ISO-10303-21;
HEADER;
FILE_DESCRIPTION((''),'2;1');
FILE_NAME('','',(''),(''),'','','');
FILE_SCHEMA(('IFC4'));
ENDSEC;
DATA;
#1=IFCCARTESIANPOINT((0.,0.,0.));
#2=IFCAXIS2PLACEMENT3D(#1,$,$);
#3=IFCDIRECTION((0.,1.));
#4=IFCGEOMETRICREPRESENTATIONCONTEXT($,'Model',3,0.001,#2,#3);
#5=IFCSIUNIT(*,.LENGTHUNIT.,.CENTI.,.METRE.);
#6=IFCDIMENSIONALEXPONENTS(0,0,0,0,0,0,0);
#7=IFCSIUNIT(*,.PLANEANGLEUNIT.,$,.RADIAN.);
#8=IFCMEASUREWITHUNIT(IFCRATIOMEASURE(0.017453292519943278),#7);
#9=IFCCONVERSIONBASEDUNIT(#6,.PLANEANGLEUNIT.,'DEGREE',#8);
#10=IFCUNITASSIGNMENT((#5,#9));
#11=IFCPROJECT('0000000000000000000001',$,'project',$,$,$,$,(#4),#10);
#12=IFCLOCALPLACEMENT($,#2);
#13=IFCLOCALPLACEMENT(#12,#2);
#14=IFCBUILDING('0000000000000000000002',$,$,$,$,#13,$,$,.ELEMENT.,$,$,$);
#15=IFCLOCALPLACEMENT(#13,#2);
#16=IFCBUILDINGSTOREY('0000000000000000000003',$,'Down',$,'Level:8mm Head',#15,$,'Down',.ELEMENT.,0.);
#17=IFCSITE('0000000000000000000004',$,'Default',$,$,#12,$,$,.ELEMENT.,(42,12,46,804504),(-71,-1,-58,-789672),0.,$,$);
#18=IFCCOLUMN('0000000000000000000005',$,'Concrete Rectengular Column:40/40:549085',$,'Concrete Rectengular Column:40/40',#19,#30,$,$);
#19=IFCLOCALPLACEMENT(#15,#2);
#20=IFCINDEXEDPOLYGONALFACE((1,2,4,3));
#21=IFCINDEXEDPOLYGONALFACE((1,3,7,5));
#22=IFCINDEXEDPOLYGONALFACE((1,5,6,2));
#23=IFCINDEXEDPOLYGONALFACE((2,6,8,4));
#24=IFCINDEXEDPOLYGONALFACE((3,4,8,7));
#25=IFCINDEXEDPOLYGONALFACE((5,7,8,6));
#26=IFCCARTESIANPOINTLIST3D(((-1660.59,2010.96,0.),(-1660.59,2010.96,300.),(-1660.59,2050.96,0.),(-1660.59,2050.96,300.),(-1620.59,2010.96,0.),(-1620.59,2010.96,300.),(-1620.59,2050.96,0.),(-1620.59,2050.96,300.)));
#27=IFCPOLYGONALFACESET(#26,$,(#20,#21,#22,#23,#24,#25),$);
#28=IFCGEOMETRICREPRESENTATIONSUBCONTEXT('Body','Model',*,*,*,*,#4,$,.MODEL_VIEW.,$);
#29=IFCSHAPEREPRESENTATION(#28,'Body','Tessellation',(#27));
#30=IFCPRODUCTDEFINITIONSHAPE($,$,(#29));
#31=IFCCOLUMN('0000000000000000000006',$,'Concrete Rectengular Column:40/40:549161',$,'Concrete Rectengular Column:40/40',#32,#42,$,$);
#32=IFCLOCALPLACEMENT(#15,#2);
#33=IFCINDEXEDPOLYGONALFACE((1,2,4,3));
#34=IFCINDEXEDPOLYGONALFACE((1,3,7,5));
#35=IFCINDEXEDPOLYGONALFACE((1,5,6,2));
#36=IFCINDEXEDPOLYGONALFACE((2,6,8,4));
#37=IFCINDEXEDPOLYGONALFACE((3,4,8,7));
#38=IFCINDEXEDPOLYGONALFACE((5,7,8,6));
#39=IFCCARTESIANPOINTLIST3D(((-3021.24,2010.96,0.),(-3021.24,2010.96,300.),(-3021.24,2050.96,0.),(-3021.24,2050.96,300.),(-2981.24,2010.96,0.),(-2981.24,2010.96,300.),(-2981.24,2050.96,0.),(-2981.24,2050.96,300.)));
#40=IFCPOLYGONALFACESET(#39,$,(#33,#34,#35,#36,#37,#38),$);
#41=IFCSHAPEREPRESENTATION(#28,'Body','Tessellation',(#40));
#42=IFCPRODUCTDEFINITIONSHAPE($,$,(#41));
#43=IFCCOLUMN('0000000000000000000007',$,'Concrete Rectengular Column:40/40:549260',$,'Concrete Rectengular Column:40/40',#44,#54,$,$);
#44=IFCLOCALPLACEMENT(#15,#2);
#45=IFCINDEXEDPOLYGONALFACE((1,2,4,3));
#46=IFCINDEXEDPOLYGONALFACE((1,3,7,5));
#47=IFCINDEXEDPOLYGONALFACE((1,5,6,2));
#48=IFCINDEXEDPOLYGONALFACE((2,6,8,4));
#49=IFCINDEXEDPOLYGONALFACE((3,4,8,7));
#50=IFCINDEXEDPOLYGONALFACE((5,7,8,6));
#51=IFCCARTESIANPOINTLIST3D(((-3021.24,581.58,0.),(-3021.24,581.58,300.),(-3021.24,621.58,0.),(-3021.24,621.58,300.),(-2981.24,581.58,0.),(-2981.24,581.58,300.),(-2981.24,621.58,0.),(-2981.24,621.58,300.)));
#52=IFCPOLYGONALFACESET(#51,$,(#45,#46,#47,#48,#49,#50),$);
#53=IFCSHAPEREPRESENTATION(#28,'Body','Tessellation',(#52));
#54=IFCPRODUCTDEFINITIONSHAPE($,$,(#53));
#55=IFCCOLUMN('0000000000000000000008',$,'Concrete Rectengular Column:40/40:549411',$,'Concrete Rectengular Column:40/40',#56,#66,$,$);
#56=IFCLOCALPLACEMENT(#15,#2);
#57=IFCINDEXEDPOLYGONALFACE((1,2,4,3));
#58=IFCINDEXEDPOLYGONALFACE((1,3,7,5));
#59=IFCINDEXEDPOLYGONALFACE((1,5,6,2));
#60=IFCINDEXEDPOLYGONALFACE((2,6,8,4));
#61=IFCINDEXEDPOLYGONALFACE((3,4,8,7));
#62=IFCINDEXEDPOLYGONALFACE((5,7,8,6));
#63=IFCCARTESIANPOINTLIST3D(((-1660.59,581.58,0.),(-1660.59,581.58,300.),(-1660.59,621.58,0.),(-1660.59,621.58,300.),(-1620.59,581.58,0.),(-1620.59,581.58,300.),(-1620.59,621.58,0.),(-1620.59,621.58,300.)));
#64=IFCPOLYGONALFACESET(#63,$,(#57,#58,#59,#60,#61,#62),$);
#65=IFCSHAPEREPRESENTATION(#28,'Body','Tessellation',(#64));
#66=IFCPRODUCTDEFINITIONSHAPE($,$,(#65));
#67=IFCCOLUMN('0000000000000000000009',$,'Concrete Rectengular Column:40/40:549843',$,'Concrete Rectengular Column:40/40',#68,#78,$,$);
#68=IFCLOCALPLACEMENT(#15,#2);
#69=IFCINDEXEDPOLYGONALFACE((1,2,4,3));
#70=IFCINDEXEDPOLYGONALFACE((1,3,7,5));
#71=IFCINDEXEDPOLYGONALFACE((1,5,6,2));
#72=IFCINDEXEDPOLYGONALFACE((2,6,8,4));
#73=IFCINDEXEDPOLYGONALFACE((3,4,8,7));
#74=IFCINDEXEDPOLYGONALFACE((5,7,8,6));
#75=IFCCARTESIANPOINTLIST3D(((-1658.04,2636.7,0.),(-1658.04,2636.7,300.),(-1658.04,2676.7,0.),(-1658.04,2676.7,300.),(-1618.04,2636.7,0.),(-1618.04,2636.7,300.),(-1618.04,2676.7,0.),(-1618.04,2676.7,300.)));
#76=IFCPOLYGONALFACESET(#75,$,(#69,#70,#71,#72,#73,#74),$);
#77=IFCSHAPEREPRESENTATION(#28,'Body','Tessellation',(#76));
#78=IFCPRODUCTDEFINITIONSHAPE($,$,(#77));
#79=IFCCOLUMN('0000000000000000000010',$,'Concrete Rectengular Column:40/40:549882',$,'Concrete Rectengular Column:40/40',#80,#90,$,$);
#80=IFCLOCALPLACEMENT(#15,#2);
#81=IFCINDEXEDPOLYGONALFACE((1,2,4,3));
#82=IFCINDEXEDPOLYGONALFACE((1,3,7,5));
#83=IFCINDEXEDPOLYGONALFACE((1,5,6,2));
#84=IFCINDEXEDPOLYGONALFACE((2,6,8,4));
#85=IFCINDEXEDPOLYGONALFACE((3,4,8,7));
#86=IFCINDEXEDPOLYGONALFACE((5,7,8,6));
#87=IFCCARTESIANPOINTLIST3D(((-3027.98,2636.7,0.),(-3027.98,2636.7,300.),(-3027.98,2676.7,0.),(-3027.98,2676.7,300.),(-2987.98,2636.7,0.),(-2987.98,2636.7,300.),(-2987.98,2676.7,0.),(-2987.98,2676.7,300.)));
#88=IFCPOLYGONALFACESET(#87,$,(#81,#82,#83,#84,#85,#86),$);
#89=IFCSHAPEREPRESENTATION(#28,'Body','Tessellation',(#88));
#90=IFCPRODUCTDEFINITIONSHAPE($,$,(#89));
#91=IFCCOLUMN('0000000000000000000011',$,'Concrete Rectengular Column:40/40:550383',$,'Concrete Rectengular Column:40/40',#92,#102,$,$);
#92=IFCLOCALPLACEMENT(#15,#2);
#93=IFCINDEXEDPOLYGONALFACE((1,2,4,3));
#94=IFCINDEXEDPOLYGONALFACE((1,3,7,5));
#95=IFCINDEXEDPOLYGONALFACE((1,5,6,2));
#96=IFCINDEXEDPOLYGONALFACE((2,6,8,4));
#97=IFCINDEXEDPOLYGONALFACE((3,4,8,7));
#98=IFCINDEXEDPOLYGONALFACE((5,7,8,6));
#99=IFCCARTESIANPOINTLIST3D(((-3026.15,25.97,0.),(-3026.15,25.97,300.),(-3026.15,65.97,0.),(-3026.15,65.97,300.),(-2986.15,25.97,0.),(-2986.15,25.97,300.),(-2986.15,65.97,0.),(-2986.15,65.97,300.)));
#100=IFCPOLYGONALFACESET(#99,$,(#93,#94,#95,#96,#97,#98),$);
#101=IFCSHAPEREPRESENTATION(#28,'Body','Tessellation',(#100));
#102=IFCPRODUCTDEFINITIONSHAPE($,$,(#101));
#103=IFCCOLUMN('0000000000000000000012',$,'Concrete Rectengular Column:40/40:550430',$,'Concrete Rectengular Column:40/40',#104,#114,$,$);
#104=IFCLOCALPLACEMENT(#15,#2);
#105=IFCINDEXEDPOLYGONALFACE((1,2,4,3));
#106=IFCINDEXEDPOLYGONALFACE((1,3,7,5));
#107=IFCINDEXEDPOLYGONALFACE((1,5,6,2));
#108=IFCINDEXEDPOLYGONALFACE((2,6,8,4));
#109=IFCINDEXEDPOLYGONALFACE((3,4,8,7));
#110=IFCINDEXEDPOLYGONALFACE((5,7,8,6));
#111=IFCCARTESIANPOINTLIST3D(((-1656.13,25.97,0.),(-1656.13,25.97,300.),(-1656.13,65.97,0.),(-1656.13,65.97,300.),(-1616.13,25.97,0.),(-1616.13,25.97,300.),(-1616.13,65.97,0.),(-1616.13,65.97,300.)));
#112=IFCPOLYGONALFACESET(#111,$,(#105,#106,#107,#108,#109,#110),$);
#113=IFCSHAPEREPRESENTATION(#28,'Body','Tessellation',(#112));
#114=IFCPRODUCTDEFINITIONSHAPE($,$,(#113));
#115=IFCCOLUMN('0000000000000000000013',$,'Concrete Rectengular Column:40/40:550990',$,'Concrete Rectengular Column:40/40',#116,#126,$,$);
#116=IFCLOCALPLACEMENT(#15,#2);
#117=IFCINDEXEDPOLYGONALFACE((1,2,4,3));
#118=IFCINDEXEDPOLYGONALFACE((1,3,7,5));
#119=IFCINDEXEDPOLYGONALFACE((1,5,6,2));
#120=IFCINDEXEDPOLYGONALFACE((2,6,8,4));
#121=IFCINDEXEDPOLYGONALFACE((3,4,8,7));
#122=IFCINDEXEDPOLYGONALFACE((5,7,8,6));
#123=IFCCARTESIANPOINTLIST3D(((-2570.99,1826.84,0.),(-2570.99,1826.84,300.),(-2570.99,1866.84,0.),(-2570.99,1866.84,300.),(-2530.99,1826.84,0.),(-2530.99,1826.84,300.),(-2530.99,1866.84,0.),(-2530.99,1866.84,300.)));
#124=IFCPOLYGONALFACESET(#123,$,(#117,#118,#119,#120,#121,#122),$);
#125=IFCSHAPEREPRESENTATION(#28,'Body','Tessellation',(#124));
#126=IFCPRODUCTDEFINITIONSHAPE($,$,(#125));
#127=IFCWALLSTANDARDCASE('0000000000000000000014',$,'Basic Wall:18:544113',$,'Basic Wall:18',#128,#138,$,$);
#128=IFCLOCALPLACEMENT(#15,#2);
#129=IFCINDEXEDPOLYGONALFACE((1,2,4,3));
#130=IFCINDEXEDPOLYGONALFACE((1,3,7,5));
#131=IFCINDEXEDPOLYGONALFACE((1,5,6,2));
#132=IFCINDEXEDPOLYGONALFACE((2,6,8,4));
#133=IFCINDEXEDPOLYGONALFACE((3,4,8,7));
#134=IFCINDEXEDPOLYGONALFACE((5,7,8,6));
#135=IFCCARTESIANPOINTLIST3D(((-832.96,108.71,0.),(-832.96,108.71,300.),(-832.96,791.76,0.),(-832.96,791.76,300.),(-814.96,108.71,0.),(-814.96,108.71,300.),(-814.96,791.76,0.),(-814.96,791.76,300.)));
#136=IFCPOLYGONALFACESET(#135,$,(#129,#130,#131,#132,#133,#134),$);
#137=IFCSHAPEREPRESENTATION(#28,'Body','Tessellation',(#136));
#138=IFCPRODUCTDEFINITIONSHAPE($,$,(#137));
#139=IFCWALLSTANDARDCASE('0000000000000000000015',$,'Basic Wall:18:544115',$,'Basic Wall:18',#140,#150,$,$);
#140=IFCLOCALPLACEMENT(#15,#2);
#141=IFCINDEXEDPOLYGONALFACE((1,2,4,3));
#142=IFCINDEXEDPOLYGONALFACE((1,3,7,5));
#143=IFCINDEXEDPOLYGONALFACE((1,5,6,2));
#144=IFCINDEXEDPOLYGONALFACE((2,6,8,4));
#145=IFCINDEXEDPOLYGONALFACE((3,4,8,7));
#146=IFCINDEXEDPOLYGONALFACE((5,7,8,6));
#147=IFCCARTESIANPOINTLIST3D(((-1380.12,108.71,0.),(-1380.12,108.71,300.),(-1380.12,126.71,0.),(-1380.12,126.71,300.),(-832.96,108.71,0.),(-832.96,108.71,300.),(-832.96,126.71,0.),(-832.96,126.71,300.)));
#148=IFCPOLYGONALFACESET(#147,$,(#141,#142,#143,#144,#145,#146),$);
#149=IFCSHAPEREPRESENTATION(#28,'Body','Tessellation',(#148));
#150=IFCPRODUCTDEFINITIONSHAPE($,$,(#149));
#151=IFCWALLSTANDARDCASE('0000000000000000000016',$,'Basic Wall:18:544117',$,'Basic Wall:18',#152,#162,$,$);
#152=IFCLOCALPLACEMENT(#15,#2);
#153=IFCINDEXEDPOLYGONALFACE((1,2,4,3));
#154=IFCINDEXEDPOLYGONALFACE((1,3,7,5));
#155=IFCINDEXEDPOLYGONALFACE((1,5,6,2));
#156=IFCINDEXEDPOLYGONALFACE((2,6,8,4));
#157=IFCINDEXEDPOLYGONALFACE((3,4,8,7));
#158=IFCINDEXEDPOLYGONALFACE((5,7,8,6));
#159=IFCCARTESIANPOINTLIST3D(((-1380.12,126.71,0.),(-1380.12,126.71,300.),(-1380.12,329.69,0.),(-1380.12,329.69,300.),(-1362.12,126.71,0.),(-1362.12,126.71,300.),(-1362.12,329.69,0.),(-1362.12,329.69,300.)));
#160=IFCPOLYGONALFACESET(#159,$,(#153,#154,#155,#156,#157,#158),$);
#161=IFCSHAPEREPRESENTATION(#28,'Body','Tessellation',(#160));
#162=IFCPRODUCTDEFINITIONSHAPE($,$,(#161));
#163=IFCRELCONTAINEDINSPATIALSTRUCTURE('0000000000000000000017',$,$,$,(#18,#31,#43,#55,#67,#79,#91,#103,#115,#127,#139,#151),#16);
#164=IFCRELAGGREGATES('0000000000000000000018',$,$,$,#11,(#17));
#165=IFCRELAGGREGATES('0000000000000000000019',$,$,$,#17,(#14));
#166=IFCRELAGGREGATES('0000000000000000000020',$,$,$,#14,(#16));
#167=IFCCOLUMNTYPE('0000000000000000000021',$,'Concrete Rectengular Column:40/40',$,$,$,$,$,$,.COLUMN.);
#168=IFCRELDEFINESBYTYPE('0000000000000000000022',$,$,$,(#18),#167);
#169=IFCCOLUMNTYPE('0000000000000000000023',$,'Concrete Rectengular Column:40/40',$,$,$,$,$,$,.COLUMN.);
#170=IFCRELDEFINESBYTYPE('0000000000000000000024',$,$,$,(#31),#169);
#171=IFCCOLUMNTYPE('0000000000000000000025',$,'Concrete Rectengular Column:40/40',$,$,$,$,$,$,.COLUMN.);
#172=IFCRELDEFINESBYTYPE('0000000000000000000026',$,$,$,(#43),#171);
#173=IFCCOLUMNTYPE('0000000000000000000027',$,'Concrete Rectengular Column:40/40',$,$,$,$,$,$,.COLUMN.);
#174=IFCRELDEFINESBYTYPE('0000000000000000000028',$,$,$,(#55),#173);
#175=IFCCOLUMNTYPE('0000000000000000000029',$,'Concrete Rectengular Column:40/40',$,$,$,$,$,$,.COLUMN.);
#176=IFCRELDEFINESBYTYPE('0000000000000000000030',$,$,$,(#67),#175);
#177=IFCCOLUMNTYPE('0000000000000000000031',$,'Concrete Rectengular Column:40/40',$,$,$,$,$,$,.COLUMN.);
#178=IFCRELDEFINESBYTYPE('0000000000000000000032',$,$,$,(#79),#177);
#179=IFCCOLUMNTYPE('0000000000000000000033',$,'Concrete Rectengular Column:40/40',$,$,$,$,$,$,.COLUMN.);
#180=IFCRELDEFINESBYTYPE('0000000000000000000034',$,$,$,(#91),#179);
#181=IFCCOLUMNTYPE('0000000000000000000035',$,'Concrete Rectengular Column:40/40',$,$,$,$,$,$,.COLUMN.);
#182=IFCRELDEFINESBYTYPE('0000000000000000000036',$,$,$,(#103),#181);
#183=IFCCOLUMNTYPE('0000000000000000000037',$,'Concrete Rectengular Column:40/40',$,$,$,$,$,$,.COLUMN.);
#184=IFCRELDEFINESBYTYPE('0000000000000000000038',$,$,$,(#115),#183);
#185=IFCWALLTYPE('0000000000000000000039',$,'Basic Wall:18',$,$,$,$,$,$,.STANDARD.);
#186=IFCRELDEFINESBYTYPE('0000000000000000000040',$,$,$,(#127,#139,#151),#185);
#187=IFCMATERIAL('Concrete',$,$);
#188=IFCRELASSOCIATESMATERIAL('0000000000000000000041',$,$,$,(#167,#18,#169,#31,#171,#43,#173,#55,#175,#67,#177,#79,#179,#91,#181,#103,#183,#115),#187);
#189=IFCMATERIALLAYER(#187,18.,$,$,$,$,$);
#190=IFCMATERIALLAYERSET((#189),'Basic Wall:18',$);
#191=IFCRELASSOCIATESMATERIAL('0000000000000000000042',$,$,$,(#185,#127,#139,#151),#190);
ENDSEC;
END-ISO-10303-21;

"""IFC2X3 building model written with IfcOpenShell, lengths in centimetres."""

from ifc_helpers import new_model, entity, si_unit, converted_unit, direction, frame, frame_2d, origin, origin_2d_with_axis, place, context, subcontext, project, spatial, rectangle, extrude, source, transform, mapped, material, layer, layer_set, layer_usage, type_object, type_shapes, element, save


model = new_model("IFC2X3")

# Units and contexts
model_context = context("Model", 3, precision=0.001, world=origin(), true_north=direction((0.0, 1.0)))
body_context = subcontext(model_context, "Body", "Model", "MODEL_VIEW")
ifc_project = project(units=[si_unit("LENGTHUNIT", "METRE", prefix="CENTI"), converted_unit("PLANEANGLEUNIT", "DEGREE", entity("IfcRatioMeasure", 0.017453292519943278), si_unit("PLANEANGLEUNIT", "RADIAN"), dimensions=[0, 0, 0, 0, 0, 0, 0])], contexts=[model_context])

# Site, building, storey
site_placement = place(None, origin())
site = spatial("IfcSite", under=ifc_project, at=site_placement, Name="Default", CompositionType="ELEMENT", RefLatitude=(42, 12, 46, 804504), RefLongitude=(-71, -1, -58, -789672), RefElevation=0.0)
building_placement = place(site_placement, origin())
building = spatial("IfcBuilding", under=site, at=building_placement, CompositionType="ELEMENT")
storey_placement = place(building_placement, origin())
storey = spatial("IfcBuildingStorey", under=building, at=storey_placement, Name="Down", ObjectType="Level:8mm Head", LongName="Down", CompositionType="ELEMENT", Elevation=0.0)

# Columns
ifc_material = material(Name="Concrete")
column_type_1 = type_object("IfcColumnType", Name="Concrete Rectengular Column:40/40", PredefinedType="COLUMN", material=ifc_material)
shared_shape_1 = source(origin(), body_context, "Body", "SweptSolid", [
    extrude(rectangle(XDim=40.0, YDim=40.0, at=frame_2d((0.0, 0.0), x_axis=(1.0, 0.0))), frame((-1640.59, 2030.96, 0.0), z_axis=(0.0, 0.0, 1.0), x_axis=(0.0, -1.0, 0.0)), (0.0, 0.0, 1.0), 300.0),
])
type_shapes(column_type_1, [shared_shape_1])
column_1_placement = place(storey_placement, origin())
element("IfcColumn", 1, at=column_1_placement, inside=storey, type_object=column_type_1, material=ifc_material, Name="Concrete Rectengular Column:40/40:549085", ObjectType="Concrete Rectengular Column:40/40", context=body_context, shape_type="MappedRepresentation", body=[
    mapped(shared_shape_1, transform((0.0, 0.0, 0.0), scale=1.0)),
])
column_type_2 = type_object("IfcColumnType", Name="Concrete Rectengular Column:40/40", PredefinedType="COLUMN", material=ifc_material)
shared_shape_2 = source(origin(), body_context, "Body", "SweptSolid", [
    extrude(rectangle(XDim=40.0, YDim=40.0, at=frame_2d((0.0, 0.0), x_axis=(1.0, 0.0))), frame((-3001.24, 2030.96, 0.0), z_axis=(0.0, 0.0, 1.0), x_axis=(0.0, -1.0, 0.0)), (0.0, 0.0, 1.0), 300.0),
])
type_shapes(column_type_2, [shared_shape_2])
column_2_placement = place(storey_placement, origin())
element("IfcColumn", 2, at=column_2_placement, inside=storey, type_object=column_type_2, material=ifc_material, Name="Concrete Rectengular Column:40/40:549161", ObjectType="Concrete Rectengular Column:40/40", context=body_context, shape_type="MappedRepresentation", body=[
    mapped(shared_shape_2, transform((0.0, 0.0, 0.0), scale=1.0)),
])
column_type_3 = type_object("IfcColumnType", Name="Concrete Rectengular Column:40/40", PredefinedType="COLUMN", material=ifc_material)
shared_shape_3 = source(origin(), body_context, "Body", "SweptSolid", [
    extrude(rectangle(XDim=40.0, YDim=40.0, at=frame_2d((0.0, 0.0), x_axis=(1.0, 0.0))), frame((-3001.24, 601.58, 0.0), z_axis=(0.0, 0.0, 1.0), x_axis=(0.0, -1.0, 0.0)), (0.0, 0.0, 1.0), 300.0),
])
type_shapes(column_type_3, [shared_shape_3])
column_3_placement = place(storey_placement, origin())
element("IfcColumn", 3, at=column_3_placement, inside=storey, type_object=column_type_3, material=ifc_material, Name="Concrete Rectengular Column:40/40:549260", ObjectType="Concrete Rectengular Column:40/40", context=body_context, shape_type="MappedRepresentation", body=[
    mapped(shared_shape_3, transform((0.0, 0.0, 0.0), scale=1.0)),
])
column_type_4 = type_object("IfcColumnType", Name="Concrete Rectengular Column:40/40", PredefinedType="COLUMN", material=ifc_material)
shared_shape_4 = source(origin(), body_context, "Body", "SweptSolid", [
    extrude(rectangle(XDim=40.0, YDim=40.0, at=origin_2d_with_axis()), frame((-1640.59, 601.58, 0.0), z_axis=(0.0, 0.0, 1.0), x_axis=(0.0, -1.0, 0.0)), (0.0, 0.0, 1.0), 300.0),
])
type_shapes(column_type_4, [shared_shape_4])
column_4_placement = place(storey_placement, origin())
element("IfcColumn", 4, at=column_4_placement, inside=storey, type_object=column_type_4, material=ifc_material, Name="Concrete Rectengular Column:40/40:549411", ObjectType="Concrete Rectengular Column:40/40", context=body_context, shape_type="MappedRepresentation", body=[
    mapped(shared_shape_4, transform((0.0, 0.0, 0.0), scale=1.0)),
])
column_type_5 = type_object("IfcColumnType", Name="Concrete Rectengular Column:40/40", PredefinedType="COLUMN", material=ifc_material)
shared_shape_5 = source(origin(), body_context, "Body", "SweptSolid", [
    extrude(rectangle(XDim=40.0, YDim=40.0, at=frame_2d((0.0, 0.0), x_axis=(1.0, 0.0))), frame((-1638.04, 2656.7, 0.0), z_axis=(0.0, 0.0, 1.0), x_axis=(0.0, -1.0, 0.0)), (0.0, 0.0, 1.0), 300.0),
])
type_shapes(column_type_5, [shared_shape_5])
column_5_placement = place(storey_placement, origin())
element("IfcColumn", 5, at=column_5_placement, inside=storey, type_object=column_type_5, material=ifc_material, Name="Concrete Rectengular Column:40/40:549843", ObjectType="Concrete Rectengular Column:40/40", context=body_context, shape_type="MappedRepresentation", body=[
    mapped(shared_shape_5, transform((0.0, 0.0, 0.0), scale=1.0)),
])
column_type_6 = type_object("IfcColumnType", Name="Concrete Rectengular Column:40/40", PredefinedType="COLUMN", material=ifc_material)
shared_shape_6 = source(origin(), body_context, "Body", "SweptSolid", [
    extrude(rectangle(XDim=40.0, YDim=40.0, at=frame_2d((0.0, 0.0), x_axis=(1.0, 0.0))), frame((-3007.98, 2656.7, 0.0), z_axis=(0.0, 0.0, 1.0), x_axis=(0.0, -1.0, 0.0)), (0.0, 0.0, 1.0), 300.0),
])
type_shapes(column_type_6, [shared_shape_6])
column_6_placement = place(storey_placement, origin())
element("IfcColumn", 6, at=column_6_placement, inside=storey, type_object=column_type_6, material=ifc_material, Name="Concrete Rectengular Column:40/40:549882", ObjectType="Concrete Rectengular Column:40/40", context=body_context, shape_type="MappedRepresentation", body=[
    mapped(shared_shape_6, transform((0.0, 0.0, 0.0), scale=1.0)),
])
column_type_7 = type_object("IfcColumnType", Name="Concrete Rectengular Column:40/40", PredefinedType="COLUMN", material=ifc_material)
shared_shape_7 = source(origin(), body_context, "Body", "SweptSolid", [
    extrude(rectangle(XDim=40.0, YDim=40.0, at=frame_2d((0.0, 0.0), x_axis=(1.0, 0.0))), frame((-3006.15, 45.97, 0.0), z_axis=(0.0, 0.0, 1.0), x_axis=(0.0, -1.0, 0.0)), (0.0, 0.0, 1.0), 300.0),
])
type_shapes(column_type_7, [shared_shape_7])
column_7_placement = place(storey_placement, origin())
element("IfcColumn", 7, at=column_7_placement, inside=storey, type_object=column_type_7, material=ifc_material, Name="Concrete Rectengular Column:40/40:550383", ObjectType="Concrete Rectengular Column:40/40", context=body_context, shape_type="MappedRepresentation", body=[
    mapped(shared_shape_7, transform((0.0, 0.0, 0.0), scale=1.0)),
])
column_type_8 = type_object("IfcColumnType", Name="Concrete Rectengular Column:40/40", PredefinedType="COLUMN", material=ifc_material)
shared_shape_8 = source(origin(), body_context, "Body", "SweptSolid", [
    extrude(rectangle(XDim=40.0, YDim=40.0, at=frame_2d((0.0, 0.0), x_axis=(1.0, 0.0))), frame((-1636.13, 45.97, 0.0), z_axis=(0.0, 0.0, 1.0), x_axis=(0.0, -1.0, 0.0)), (0.0, 0.0, 1.0), 300.0),
])
type_shapes(column_type_8, [shared_shape_8])
column_8_placement = place(storey_placement, origin())
element("IfcColumn", 8, at=column_8_placement, inside=storey, type_object=column_type_8, material=ifc_material, Name="Concrete Rectengular Column:40/40:550430", ObjectType="Concrete Rectengular Column:40/40", context=body_context, shape_type="MappedRepresentation", body=[
    mapped(shared_shape_8, transform((0.0, 0.0, 0.0), scale=1.0)),
])
column_type_9 = type_object("IfcColumnType", Name="Concrete Rectengular Column:40/40", PredefinedType="COLUMN", material=ifc_material)
shared_shape_9 = source(origin(), body_context, "Body", "SweptSolid", [
    extrude(rectangle(XDim=40.0, YDim=40.0, at=frame_2d((0.0, 0.0), x_axis=(1.0, 0.0))), frame((-2550.99, 1846.84, 0.0), z_axis=(0.0, 0.0, 1.0), x_axis=(0.0, -1.0, 0.0)), (0.0, 0.0, 1.0), 300.0),
])
type_shapes(column_type_9, [shared_shape_9])
column_9_placement = place(storey_placement, origin())
element("IfcColumn", 9, at=column_9_placement, inside=storey, type_object=column_type_9, material=ifc_material, Name="Concrete Rectengular Column:40/40:550990", ObjectType="Concrete Rectengular Column:40/40", context=body_context, shape_type="MappedRepresentation", body=[
    mapped(shared_shape_9, transform((0.0, 0.0, 0.0), scale=1.0)),
])

# Walls
ifc_layer_1 = layer(ifc_material, 18.0)
ifc_layer_set_1 = layer_set([ifc_layer_1], Name="Basic Wall:18")
ifc_layer_usage_1 = layer_usage(ifc_layer_set_1, "AXIS2", "NEGATIVE", 9.0)
wall_type_1 = type_object("IfcWallType", Name="Basic Wall:18", PredefinedType="STANDARD", material=ifc_layer_set_1)
wall_1_placement = place(storey_placement, frame((-823.96, 791.76, 0.0), z_axis=(0.0, 0.0, 1.0), x_axis=(0.0, -1.0, 0.0)))
element("IfcWallStandardCase", 10, at=wall_1_placement, inside=storey, type_object=wall_type_1, material=ifc_layer_usage_1, Name="Basic Wall:18:544113", ObjectType="Basic Wall:18", context=body_context, shape_type="SweptSolid", body=[
    extrude(rectangle(XDim=683.05, YDim=18.0, at=frame_2d((341.53, 0.0), x_axis=(-1.0, 0.0))), origin(), (0.0, 0.0, 1.0), 300.0),
])
ifc_layer_usage_2 = layer_usage(ifc_layer_set_1, "AXIS2", "NEGATIVE", 9.0)
wall_2_placement = place(storey_placement, frame((-832.96, 117.71, 0.0), z_axis=(0.0, 0.0, 1.0), x_axis=(-1.0, 0.0, 0.0)))
element("IfcWallStandardCase", 11, at=wall_2_placement, inside=storey, type_object=wall_type_1, material=ifc_layer_usage_2, Name="Basic Wall:18:544115", ObjectType="Basic Wall:18", context=body_context, shape_type="SweptSolid", body=[
    extrude(rectangle(XDim=547.16, YDim=18.0, at=frame_2d((273.58, 0.0), x_axis=(-1.0, 0.0))), origin(), (0.0, 0.0, 1.0), 300.0),
])
ifc_layer_usage_3 = layer_usage(ifc_layer_set_1, "AXIS2", "NEGATIVE", 9.0)
wall_3_placement = place(storey_placement, frame((-1371.12, 126.71, 0.0), z_axis=(0.0, 0.0, 1.0), x_axis=(0.0, 1.0, 0.0)))
element("IfcWallStandardCase", 12, at=wall_3_placement, inside=storey, type_object=wall_type_1, material=ifc_layer_usage_3, Name="Basic Wall:18:544117", ObjectType="Basic Wall:18", context=body_context, shape_type="SweptSolid", body=[
    extrude(rectangle(XDim=202.98, YDim=18.0, at=frame_2d((101.49, 0.0), x_axis=(-1.0, 0.0))), origin(), (0.0, 0.0, 1.0), 300.0),
])

save(model, "model.ifc")
